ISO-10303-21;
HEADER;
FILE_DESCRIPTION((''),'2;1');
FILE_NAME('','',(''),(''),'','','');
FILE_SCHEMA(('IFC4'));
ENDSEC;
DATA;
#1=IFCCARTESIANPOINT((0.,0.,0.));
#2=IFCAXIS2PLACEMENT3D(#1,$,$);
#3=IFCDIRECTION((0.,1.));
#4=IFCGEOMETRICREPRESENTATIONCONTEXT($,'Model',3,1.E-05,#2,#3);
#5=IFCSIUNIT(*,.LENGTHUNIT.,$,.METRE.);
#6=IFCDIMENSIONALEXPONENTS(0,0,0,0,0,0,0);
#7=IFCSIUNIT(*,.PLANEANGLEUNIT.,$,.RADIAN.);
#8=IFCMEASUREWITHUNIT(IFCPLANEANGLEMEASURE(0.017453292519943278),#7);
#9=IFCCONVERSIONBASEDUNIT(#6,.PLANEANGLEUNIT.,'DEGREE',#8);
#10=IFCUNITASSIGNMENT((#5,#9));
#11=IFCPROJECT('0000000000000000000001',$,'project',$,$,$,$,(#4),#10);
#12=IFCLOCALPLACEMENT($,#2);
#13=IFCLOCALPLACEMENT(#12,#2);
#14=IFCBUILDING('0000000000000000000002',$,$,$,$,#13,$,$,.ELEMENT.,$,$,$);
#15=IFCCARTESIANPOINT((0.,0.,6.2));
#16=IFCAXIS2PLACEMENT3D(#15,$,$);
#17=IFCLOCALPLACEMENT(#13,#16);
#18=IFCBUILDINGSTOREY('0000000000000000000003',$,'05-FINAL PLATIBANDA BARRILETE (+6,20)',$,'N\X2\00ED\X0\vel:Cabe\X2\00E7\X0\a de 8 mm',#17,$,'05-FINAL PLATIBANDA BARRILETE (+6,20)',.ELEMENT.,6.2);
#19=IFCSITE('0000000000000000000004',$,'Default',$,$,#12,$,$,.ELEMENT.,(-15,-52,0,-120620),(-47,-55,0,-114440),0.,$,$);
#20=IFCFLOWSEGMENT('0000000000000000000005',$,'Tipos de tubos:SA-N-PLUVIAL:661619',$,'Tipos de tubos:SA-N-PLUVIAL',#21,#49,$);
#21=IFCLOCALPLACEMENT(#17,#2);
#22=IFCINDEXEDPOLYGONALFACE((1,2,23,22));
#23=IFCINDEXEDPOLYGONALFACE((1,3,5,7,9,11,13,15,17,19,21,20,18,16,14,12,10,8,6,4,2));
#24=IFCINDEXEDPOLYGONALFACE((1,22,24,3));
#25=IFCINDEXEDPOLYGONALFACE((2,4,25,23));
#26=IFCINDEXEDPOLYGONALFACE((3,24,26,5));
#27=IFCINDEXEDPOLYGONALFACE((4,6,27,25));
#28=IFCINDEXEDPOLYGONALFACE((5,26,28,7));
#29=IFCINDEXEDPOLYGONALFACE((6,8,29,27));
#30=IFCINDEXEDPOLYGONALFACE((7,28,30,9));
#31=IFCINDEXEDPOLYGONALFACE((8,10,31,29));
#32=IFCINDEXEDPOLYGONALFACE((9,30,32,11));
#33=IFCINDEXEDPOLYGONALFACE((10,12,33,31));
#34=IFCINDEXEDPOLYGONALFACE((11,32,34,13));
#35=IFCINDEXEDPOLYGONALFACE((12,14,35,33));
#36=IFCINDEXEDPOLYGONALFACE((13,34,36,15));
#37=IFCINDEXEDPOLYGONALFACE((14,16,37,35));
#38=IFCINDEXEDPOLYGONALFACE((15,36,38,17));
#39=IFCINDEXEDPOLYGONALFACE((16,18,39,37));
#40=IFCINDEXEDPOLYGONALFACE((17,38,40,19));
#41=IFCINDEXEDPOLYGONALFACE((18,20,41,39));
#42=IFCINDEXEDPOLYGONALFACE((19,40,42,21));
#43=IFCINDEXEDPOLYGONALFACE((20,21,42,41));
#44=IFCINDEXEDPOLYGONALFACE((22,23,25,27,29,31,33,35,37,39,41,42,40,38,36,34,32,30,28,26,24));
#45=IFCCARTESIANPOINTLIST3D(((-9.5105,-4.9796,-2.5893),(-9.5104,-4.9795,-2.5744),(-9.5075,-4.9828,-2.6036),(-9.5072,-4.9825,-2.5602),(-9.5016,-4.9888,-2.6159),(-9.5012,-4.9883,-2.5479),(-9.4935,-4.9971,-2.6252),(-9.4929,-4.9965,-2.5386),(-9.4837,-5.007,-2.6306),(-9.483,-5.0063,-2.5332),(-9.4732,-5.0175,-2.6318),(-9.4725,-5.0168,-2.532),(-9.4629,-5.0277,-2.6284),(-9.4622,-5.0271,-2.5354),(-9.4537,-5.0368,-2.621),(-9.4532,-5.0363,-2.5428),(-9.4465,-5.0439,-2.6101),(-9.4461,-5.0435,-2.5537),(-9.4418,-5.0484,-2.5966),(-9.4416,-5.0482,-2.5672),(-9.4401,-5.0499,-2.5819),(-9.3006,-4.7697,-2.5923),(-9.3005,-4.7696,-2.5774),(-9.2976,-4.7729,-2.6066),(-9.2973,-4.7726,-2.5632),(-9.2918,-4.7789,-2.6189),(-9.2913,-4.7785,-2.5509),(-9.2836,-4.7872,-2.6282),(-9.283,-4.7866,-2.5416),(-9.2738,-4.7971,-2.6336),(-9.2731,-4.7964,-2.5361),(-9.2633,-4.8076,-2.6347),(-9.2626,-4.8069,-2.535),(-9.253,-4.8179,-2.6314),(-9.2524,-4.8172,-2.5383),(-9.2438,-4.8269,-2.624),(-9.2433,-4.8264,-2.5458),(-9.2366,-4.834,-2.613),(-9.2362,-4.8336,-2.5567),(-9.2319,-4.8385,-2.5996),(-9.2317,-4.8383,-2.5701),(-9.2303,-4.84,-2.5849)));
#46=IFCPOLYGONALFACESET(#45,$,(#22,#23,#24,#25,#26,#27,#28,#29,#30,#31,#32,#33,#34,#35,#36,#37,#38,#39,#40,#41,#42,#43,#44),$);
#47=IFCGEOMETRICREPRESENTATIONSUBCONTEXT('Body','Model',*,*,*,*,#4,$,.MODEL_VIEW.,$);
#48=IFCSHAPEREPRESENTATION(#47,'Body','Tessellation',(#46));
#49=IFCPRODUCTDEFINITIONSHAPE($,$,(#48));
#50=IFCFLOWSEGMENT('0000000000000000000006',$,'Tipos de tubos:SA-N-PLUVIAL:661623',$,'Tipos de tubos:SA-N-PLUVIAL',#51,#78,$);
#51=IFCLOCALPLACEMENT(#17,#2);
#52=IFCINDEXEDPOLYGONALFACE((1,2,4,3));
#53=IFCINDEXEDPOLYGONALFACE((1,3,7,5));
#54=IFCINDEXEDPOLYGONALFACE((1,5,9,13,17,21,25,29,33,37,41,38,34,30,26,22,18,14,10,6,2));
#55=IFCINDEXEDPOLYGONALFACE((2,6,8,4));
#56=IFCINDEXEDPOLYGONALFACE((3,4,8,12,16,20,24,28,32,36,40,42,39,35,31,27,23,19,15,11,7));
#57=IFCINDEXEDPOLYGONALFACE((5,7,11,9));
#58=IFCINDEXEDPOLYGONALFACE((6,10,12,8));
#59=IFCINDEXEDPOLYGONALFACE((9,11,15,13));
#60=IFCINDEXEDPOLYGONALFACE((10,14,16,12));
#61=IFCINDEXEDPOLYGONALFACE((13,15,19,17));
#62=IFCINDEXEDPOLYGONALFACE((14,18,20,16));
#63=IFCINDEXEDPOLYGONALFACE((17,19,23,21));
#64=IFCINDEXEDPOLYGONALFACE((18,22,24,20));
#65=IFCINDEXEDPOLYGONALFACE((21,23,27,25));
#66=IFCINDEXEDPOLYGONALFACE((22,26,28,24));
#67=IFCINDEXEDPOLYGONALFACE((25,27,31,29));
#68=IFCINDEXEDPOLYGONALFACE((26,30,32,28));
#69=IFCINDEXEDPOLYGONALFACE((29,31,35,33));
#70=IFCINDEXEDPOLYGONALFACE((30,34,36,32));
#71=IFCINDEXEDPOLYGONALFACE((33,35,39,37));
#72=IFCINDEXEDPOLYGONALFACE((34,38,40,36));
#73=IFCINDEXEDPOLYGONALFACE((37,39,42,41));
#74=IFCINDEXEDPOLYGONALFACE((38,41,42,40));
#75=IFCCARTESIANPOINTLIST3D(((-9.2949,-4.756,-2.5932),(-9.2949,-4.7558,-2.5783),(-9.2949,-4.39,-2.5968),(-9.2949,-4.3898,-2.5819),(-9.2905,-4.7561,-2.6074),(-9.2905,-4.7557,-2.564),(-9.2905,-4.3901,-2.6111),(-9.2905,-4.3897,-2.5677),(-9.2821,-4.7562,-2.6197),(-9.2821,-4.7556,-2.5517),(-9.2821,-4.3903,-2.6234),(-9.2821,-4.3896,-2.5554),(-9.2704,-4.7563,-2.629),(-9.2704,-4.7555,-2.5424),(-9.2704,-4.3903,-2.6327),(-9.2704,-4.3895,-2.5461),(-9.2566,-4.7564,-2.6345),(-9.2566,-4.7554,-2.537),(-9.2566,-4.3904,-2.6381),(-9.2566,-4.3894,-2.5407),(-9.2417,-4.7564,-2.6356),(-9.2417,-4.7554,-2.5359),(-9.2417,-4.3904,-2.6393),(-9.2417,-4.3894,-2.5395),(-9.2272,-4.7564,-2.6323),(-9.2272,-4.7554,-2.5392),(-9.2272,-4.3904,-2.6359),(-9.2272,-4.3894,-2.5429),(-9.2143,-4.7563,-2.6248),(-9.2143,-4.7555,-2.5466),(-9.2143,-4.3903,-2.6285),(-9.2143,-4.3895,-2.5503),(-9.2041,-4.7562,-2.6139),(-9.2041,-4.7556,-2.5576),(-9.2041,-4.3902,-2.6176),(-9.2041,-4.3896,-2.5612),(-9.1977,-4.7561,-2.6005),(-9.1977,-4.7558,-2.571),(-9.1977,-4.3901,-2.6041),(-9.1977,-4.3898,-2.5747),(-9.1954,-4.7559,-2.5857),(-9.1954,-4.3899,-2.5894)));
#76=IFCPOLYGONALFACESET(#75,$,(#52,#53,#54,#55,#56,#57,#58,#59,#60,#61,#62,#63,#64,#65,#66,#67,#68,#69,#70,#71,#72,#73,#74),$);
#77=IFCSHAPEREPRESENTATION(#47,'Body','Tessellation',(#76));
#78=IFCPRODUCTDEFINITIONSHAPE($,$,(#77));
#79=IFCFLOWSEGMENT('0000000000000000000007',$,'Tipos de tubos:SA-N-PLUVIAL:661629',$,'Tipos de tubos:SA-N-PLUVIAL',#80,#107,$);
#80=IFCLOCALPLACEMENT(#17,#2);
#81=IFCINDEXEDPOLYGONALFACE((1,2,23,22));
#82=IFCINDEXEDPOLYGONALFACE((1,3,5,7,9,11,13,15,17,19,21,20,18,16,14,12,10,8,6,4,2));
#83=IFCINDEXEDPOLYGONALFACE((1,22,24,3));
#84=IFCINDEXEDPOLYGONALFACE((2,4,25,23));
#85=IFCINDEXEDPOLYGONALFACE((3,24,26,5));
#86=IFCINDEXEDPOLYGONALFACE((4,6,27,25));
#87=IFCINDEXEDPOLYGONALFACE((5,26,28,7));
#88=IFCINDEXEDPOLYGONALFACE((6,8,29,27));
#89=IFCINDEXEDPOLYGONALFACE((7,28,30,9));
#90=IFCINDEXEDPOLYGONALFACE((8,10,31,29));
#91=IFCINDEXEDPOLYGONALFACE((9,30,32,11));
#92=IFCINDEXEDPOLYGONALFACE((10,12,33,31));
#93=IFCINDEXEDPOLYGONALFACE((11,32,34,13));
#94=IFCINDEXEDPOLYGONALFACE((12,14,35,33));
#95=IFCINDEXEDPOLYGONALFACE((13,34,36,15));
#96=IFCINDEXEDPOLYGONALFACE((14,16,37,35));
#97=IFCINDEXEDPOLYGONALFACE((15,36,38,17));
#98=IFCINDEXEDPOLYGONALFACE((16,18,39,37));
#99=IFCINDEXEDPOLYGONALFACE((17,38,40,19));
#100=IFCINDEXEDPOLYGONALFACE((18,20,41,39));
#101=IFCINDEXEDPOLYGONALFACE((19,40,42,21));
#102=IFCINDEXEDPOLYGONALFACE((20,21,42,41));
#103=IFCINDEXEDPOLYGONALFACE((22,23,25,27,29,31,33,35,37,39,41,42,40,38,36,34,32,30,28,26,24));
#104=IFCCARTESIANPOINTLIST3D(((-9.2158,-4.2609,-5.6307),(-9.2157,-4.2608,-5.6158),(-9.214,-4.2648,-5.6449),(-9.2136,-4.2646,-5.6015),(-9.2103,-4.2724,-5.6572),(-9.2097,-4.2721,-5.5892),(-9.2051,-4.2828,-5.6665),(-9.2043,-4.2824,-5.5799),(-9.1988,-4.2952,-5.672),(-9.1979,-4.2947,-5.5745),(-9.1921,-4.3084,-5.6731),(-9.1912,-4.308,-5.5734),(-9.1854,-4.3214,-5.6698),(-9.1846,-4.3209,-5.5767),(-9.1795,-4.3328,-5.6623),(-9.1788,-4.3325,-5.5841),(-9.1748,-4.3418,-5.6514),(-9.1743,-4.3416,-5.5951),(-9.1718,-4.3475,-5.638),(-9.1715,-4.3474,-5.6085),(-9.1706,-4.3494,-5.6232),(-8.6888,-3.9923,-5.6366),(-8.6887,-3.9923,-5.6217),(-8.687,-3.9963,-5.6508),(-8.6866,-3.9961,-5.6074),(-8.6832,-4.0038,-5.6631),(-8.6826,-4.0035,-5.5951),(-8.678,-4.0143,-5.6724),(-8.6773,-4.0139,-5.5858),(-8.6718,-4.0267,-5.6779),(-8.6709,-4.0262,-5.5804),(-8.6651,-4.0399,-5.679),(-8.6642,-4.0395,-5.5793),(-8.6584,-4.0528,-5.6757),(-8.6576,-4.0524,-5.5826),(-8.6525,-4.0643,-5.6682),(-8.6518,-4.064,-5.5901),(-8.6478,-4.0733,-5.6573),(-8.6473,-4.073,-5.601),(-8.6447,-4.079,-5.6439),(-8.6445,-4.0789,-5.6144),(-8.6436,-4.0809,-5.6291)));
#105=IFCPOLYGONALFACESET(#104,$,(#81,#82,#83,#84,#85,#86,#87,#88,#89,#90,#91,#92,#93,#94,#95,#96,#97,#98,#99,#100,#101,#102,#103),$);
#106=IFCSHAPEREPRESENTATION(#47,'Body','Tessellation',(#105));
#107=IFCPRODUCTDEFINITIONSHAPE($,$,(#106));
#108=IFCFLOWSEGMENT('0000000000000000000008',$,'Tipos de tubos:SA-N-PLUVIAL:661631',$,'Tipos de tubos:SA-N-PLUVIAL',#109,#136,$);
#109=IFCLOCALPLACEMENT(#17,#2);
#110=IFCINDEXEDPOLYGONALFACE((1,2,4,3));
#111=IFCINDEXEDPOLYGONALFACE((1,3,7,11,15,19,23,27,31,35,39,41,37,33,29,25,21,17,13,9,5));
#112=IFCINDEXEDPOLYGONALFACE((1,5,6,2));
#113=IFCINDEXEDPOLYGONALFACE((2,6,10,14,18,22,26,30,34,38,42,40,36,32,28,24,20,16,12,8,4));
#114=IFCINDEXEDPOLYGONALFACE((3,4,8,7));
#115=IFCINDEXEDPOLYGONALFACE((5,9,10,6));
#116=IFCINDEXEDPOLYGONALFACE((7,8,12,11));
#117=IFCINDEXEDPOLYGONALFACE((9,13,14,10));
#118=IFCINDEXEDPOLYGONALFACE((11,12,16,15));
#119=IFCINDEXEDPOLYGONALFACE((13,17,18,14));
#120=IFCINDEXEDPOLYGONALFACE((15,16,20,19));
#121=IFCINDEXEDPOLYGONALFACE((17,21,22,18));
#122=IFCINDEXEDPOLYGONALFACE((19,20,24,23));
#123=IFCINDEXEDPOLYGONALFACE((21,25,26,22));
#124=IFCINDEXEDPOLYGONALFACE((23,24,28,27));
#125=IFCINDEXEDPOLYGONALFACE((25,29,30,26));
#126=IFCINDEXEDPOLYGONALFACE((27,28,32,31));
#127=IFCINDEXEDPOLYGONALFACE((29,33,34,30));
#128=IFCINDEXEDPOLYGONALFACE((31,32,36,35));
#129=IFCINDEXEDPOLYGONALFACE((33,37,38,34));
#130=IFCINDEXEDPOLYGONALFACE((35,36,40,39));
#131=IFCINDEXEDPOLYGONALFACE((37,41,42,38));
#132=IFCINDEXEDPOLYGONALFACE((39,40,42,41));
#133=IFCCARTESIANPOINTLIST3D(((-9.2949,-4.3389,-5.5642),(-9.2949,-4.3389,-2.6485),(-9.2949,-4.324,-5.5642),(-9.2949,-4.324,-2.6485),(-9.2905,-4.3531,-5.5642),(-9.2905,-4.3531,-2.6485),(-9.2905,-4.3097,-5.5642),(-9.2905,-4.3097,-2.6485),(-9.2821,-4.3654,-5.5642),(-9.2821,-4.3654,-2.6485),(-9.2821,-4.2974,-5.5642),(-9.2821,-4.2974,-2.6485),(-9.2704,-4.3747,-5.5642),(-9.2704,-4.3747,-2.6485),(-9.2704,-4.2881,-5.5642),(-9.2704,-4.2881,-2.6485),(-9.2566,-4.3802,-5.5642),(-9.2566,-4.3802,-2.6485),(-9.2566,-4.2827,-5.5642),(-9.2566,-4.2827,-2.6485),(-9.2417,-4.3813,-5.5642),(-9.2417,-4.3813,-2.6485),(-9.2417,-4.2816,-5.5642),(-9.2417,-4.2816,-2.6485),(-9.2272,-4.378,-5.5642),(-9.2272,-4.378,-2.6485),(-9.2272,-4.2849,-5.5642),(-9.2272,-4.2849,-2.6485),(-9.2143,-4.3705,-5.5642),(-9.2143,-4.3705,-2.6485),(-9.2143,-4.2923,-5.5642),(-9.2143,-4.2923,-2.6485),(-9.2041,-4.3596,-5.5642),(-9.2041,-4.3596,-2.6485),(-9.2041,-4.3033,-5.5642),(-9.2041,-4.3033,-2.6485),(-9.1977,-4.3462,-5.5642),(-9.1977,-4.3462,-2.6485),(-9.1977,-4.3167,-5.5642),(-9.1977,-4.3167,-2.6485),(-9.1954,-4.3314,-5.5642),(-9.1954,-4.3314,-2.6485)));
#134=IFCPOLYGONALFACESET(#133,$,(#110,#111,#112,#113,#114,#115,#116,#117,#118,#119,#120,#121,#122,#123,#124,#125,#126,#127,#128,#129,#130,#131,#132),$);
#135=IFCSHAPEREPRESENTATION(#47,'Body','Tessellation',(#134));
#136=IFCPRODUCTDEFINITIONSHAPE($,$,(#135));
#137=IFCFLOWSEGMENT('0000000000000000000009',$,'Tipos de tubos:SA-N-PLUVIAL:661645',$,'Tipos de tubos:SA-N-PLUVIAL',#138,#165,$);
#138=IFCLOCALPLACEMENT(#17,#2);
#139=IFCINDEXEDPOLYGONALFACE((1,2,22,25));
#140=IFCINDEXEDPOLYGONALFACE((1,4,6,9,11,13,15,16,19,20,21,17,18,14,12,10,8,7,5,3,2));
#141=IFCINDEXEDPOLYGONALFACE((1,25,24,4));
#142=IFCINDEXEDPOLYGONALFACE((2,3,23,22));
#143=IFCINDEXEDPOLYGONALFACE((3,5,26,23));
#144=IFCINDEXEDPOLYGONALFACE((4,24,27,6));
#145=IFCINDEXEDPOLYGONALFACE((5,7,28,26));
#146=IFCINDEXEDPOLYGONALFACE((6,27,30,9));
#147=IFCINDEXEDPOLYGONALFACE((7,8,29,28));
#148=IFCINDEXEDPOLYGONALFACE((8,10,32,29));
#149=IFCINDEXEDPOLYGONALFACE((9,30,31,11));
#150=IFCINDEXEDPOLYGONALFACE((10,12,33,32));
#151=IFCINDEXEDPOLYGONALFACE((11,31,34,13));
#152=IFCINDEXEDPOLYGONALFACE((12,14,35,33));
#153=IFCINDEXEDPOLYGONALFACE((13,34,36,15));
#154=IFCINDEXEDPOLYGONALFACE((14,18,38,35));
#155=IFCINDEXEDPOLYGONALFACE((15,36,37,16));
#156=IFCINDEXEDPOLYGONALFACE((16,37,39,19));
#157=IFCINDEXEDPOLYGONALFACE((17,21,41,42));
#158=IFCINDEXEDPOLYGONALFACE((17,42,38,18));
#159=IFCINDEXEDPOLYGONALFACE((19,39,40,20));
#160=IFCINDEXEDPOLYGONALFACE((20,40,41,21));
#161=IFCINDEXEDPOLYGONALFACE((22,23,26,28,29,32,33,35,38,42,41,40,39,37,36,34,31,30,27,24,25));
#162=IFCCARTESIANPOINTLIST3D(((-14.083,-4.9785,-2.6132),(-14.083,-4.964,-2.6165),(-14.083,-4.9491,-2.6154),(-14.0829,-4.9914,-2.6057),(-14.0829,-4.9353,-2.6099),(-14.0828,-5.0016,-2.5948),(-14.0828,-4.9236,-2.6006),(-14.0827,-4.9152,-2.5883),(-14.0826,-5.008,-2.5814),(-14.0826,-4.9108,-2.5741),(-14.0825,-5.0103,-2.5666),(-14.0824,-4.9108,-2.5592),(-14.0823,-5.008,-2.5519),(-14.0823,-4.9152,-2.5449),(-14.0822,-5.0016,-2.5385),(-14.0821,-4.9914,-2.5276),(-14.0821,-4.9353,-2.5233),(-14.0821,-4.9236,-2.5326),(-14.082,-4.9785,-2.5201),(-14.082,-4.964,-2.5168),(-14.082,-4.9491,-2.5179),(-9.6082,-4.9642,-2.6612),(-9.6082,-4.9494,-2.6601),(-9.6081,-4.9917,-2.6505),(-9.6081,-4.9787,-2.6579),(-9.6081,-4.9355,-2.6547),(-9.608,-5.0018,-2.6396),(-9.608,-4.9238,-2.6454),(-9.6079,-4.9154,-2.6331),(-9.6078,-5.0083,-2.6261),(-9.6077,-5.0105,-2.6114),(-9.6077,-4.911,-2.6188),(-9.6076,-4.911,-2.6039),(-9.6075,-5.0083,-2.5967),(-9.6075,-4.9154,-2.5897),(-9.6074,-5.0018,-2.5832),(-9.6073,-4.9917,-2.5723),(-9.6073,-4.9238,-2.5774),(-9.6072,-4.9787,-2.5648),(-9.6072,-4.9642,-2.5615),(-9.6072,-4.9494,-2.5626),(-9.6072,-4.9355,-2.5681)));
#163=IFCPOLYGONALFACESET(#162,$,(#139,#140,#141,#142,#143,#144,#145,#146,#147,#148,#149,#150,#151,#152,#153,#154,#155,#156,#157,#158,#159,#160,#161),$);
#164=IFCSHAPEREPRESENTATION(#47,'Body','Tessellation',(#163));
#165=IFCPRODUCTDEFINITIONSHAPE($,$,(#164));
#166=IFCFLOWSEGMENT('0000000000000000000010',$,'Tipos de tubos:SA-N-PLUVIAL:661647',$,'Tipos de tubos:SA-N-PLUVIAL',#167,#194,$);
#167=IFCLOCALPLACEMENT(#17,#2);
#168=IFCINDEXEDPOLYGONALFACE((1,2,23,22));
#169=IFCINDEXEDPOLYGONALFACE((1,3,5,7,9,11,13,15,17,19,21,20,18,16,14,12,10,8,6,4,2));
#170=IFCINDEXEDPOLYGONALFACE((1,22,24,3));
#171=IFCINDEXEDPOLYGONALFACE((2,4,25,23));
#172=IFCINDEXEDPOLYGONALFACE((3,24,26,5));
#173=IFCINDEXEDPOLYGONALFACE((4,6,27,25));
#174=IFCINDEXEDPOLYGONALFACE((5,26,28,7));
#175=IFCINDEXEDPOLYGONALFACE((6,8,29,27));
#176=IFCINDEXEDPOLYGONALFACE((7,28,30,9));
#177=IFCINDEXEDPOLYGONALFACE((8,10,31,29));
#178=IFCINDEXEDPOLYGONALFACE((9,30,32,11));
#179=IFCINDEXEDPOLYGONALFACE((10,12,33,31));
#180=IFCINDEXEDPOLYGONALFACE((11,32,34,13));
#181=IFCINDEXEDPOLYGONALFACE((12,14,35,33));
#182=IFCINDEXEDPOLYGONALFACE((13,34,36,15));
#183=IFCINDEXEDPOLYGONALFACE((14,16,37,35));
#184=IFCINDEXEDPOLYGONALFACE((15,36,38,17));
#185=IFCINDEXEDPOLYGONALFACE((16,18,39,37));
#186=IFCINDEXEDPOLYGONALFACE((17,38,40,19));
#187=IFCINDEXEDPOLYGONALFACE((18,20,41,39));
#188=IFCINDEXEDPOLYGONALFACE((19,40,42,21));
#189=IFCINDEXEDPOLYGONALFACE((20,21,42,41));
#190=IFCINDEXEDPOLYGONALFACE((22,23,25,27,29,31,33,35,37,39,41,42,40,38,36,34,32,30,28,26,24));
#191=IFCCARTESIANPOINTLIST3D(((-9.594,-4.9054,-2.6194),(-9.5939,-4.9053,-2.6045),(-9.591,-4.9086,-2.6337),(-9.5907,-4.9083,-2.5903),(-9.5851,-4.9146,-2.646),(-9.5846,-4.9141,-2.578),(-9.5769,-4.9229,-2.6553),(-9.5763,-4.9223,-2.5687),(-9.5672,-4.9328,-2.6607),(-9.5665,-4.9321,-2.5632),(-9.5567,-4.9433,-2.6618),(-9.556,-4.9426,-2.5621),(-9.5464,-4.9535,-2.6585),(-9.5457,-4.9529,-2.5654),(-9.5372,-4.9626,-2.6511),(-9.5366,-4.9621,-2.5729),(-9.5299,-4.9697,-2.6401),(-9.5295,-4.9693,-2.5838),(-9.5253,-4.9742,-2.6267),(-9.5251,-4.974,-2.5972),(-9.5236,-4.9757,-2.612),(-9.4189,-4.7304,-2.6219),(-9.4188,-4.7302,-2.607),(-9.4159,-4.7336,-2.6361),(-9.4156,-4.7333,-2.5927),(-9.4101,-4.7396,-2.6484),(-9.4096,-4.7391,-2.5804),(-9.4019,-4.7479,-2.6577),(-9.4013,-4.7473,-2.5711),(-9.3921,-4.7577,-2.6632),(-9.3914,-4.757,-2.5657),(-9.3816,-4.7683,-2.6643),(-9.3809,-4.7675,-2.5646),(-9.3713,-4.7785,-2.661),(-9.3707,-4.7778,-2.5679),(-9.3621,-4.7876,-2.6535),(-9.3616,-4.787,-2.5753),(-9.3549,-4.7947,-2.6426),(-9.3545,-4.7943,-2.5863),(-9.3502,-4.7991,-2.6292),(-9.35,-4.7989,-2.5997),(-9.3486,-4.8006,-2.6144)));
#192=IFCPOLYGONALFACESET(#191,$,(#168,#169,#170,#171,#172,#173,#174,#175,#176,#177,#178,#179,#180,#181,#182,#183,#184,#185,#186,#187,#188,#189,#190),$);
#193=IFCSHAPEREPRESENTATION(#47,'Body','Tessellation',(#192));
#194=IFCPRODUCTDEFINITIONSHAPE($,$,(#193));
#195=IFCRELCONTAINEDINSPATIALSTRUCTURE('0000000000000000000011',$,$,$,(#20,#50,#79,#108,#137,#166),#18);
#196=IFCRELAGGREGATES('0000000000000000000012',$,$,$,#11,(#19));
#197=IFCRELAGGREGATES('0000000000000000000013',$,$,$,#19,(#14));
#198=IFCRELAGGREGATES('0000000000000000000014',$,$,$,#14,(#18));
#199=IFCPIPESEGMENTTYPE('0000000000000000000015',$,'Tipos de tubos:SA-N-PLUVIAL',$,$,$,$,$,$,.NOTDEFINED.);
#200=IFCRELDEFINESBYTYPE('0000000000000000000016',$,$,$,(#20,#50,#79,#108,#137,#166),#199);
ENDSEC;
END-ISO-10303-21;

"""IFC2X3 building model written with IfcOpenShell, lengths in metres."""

from ifc_helpers import new_model, entity, si_unit, converted_unit, direction, frame, frame_2d, origin, origin_2d_with_axis, place, context, subcontext, project, spatial, circle, extrude, type_object, element, save


model = new_model("IFC2X3")

# Units and contexts
model_context = context("Model", 3, precision=1e-05, world=origin(), true_north=direction((0.0, 1.0)))
body_context = subcontext(model_context, "Body", "Model", "MODEL_VIEW")
ifc_project = project(units=[si_unit("LENGTHUNIT", "METRE"), converted_unit("PLANEANGLEUNIT", "DEGREE", entity("IfcPlaneAngleMeasure", 0.017453292519943278), si_unit("PLANEANGLEUNIT", "RADIAN"), dimensions=[0, 0, 0, 0, 0, 0, 0])], contexts=[model_context])

# Site, building, storey
site_placement = place(None, origin())
site = spatial("IfcSite", under=ifc_project, at=site_placement, Name="Default", CompositionType="ELEMENT", RefLatitude=(-15, -52, 0, -120620), RefLongitude=(-47, -55, 0, -114440), RefElevation=0.0)
building_placement = place(site_placement, origin())
building = spatial("IfcBuilding", under=site, at=building_placement, CompositionType="ELEMENT")
storey_placement = place(building_placement, frame((0.0, 0.0, 6.2)))
storey = spatial("IfcBuildingStorey", under=building, at=storey_placement, Name="05-FINAL PLATIBANDA BARRILETE (+6,20)", ObjectType="Nível:Cabeça de 8 mm", LongName="05-FINAL PLATIBANDA BARRILETE (+6,20)", CompositionType="ELEMENT", Elevation=6.2)

# Flow segments
pipe_segment_type = type_object("IfcPipeSegmentType", Name="Tipos de tubos:SA-N-PLUVIAL", PredefinedType="NOTDEFINED")
flow_segment_1_placement = place(storey_placement, origin())
element("IfcFlowSegment", 1, at=flow_segment_1_placement, inside=storey, type_object=pipe_segment_type, Name="Tipos de tubos:SA-N-PLUVIAL:661619", ObjectType="Tipos de tubos:SA-N-PLUVIAL", context=body_context, shape_type="SweptSolid", body=[
    extrude(circle(Radius=0.05, at=origin_2d_with_axis()), frame((-9.4755, -5.0145, -2.5819), z_axis=(0.707071, 0.707072, -0.01), x_axis=(0.707107, -0.707106, 0.0)), (0.0, 0.0, 1.0), 0.2968),
])
flow_segment_2_placement = place(storey_placement, origin())
element("IfcFlowSegment", 2, at=flow_segment_2_placement, inside=storey, type_object=pipe_segment_type, Name="Tipos de tubos:SA-N-PLUVIAL:661623", ObjectType="Tipos de tubos:SA-N-PLUVIAL", context=body_context, shape_type="SweptSolid", body=[
    extrude(circle(Radius=0.05, at=origin_2d_with_axis()), frame((-9.2454, -4.3899, -2.5894), z_axis=(0.000001, -0.99995, 0.01), x_axis=(1.0, 0.000001, 0.0)), (0.0, 0.0, 1.0), 0.366),
])
flow_segment_3_placement = place(storey_placement, origin())
element("IfcFlowSegment", 3, at=flow_segment_3_placement, inside=storey, type_object=pipe_segment_type, Name="Tipos de tubos:SA-N-PLUVIAL:661629", ObjectType="Tipos de tubos:SA-N-PLUVIAL", context=body_context, shape_type="SweptSolid", body=[
    extrude(circle(Radius=0.05, at=frame_2d((0.0, 0.0), x_axis=(1.0, 0.0))), frame((-8.6663, -4.0364, -5.6291), z_axis=(-0.890962, -0.453968, 0.01), x_axis=(0.453991, -0.891006, 0.0)), (0.0, 0.0, 1.0), 0.5915),
])
flow_segment_4_placement = place(storey_placement, origin())
element("IfcFlowSegment", 4, at=flow_segment_4_placement, inside=storey, type_object=pipe_segment_type, Name="Tipos de tubos:SA-N-PLUVIAL:661631", ObjectType="Tipos de tubos:SA-N-PLUVIAL", context=body_context, shape_type="SweptSolid", body=[
    extrude(circle(Radius=0.05, at=origin_2d_with_axis()), frame((-9.2454, -4.3314, -5.5642)), (0.0, 0.0, 1.0), 2.9157),
])
flow_segment_5_placement = place(storey_placement, origin())
element("IfcFlowSegment", 5, at=flow_segment_5_placement, inside=storey, type_object=pipe_segment_type, Name="Tipos de tubos:SA-N-PLUVIAL:661645", ObjectType="Tipos de tubos:SA-N-PLUVIAL", context=body_context, shape_type="SweptSolid", body=[
    extrude(circle(Radius=0.05, at=frame_2d((0.0, 0.0), x_axis=(1.0, 0.0))), frame((-9.6077, -4.9605, -2.6114), z_axis=(-0.99995, 0.000049, 0.01), x_axis=(-0.000049, -1.0, 0.0)), (0.0, 0.0, 1.0), 4.475),
])
flow_segment_6_placement = place(storey_placement, origin())
element("IfcFlowSegment", 6, at=flow_segment_6_placement, inside=storey, type_object=pipe_segment_type, Name="Tipos de tubos:SA-N-PLUVIAL:661647", ObjectType="Tipos de tubos:SA-N-PLUVIAL", context=body_context, shape_type="SweptSolid", body=[
    extrude(circle(Radius=0.05, at=origin_2d_with_axis()), frame((-9.559, -4.9403, -2.612), z_axis=(0.707071, 0.707072, -0.01), x_axis=(0.707107, -0.707106, 0.0)), (0.0, 0.0, 1.0), 0.2476),
])

save(model, "model.ifc")
